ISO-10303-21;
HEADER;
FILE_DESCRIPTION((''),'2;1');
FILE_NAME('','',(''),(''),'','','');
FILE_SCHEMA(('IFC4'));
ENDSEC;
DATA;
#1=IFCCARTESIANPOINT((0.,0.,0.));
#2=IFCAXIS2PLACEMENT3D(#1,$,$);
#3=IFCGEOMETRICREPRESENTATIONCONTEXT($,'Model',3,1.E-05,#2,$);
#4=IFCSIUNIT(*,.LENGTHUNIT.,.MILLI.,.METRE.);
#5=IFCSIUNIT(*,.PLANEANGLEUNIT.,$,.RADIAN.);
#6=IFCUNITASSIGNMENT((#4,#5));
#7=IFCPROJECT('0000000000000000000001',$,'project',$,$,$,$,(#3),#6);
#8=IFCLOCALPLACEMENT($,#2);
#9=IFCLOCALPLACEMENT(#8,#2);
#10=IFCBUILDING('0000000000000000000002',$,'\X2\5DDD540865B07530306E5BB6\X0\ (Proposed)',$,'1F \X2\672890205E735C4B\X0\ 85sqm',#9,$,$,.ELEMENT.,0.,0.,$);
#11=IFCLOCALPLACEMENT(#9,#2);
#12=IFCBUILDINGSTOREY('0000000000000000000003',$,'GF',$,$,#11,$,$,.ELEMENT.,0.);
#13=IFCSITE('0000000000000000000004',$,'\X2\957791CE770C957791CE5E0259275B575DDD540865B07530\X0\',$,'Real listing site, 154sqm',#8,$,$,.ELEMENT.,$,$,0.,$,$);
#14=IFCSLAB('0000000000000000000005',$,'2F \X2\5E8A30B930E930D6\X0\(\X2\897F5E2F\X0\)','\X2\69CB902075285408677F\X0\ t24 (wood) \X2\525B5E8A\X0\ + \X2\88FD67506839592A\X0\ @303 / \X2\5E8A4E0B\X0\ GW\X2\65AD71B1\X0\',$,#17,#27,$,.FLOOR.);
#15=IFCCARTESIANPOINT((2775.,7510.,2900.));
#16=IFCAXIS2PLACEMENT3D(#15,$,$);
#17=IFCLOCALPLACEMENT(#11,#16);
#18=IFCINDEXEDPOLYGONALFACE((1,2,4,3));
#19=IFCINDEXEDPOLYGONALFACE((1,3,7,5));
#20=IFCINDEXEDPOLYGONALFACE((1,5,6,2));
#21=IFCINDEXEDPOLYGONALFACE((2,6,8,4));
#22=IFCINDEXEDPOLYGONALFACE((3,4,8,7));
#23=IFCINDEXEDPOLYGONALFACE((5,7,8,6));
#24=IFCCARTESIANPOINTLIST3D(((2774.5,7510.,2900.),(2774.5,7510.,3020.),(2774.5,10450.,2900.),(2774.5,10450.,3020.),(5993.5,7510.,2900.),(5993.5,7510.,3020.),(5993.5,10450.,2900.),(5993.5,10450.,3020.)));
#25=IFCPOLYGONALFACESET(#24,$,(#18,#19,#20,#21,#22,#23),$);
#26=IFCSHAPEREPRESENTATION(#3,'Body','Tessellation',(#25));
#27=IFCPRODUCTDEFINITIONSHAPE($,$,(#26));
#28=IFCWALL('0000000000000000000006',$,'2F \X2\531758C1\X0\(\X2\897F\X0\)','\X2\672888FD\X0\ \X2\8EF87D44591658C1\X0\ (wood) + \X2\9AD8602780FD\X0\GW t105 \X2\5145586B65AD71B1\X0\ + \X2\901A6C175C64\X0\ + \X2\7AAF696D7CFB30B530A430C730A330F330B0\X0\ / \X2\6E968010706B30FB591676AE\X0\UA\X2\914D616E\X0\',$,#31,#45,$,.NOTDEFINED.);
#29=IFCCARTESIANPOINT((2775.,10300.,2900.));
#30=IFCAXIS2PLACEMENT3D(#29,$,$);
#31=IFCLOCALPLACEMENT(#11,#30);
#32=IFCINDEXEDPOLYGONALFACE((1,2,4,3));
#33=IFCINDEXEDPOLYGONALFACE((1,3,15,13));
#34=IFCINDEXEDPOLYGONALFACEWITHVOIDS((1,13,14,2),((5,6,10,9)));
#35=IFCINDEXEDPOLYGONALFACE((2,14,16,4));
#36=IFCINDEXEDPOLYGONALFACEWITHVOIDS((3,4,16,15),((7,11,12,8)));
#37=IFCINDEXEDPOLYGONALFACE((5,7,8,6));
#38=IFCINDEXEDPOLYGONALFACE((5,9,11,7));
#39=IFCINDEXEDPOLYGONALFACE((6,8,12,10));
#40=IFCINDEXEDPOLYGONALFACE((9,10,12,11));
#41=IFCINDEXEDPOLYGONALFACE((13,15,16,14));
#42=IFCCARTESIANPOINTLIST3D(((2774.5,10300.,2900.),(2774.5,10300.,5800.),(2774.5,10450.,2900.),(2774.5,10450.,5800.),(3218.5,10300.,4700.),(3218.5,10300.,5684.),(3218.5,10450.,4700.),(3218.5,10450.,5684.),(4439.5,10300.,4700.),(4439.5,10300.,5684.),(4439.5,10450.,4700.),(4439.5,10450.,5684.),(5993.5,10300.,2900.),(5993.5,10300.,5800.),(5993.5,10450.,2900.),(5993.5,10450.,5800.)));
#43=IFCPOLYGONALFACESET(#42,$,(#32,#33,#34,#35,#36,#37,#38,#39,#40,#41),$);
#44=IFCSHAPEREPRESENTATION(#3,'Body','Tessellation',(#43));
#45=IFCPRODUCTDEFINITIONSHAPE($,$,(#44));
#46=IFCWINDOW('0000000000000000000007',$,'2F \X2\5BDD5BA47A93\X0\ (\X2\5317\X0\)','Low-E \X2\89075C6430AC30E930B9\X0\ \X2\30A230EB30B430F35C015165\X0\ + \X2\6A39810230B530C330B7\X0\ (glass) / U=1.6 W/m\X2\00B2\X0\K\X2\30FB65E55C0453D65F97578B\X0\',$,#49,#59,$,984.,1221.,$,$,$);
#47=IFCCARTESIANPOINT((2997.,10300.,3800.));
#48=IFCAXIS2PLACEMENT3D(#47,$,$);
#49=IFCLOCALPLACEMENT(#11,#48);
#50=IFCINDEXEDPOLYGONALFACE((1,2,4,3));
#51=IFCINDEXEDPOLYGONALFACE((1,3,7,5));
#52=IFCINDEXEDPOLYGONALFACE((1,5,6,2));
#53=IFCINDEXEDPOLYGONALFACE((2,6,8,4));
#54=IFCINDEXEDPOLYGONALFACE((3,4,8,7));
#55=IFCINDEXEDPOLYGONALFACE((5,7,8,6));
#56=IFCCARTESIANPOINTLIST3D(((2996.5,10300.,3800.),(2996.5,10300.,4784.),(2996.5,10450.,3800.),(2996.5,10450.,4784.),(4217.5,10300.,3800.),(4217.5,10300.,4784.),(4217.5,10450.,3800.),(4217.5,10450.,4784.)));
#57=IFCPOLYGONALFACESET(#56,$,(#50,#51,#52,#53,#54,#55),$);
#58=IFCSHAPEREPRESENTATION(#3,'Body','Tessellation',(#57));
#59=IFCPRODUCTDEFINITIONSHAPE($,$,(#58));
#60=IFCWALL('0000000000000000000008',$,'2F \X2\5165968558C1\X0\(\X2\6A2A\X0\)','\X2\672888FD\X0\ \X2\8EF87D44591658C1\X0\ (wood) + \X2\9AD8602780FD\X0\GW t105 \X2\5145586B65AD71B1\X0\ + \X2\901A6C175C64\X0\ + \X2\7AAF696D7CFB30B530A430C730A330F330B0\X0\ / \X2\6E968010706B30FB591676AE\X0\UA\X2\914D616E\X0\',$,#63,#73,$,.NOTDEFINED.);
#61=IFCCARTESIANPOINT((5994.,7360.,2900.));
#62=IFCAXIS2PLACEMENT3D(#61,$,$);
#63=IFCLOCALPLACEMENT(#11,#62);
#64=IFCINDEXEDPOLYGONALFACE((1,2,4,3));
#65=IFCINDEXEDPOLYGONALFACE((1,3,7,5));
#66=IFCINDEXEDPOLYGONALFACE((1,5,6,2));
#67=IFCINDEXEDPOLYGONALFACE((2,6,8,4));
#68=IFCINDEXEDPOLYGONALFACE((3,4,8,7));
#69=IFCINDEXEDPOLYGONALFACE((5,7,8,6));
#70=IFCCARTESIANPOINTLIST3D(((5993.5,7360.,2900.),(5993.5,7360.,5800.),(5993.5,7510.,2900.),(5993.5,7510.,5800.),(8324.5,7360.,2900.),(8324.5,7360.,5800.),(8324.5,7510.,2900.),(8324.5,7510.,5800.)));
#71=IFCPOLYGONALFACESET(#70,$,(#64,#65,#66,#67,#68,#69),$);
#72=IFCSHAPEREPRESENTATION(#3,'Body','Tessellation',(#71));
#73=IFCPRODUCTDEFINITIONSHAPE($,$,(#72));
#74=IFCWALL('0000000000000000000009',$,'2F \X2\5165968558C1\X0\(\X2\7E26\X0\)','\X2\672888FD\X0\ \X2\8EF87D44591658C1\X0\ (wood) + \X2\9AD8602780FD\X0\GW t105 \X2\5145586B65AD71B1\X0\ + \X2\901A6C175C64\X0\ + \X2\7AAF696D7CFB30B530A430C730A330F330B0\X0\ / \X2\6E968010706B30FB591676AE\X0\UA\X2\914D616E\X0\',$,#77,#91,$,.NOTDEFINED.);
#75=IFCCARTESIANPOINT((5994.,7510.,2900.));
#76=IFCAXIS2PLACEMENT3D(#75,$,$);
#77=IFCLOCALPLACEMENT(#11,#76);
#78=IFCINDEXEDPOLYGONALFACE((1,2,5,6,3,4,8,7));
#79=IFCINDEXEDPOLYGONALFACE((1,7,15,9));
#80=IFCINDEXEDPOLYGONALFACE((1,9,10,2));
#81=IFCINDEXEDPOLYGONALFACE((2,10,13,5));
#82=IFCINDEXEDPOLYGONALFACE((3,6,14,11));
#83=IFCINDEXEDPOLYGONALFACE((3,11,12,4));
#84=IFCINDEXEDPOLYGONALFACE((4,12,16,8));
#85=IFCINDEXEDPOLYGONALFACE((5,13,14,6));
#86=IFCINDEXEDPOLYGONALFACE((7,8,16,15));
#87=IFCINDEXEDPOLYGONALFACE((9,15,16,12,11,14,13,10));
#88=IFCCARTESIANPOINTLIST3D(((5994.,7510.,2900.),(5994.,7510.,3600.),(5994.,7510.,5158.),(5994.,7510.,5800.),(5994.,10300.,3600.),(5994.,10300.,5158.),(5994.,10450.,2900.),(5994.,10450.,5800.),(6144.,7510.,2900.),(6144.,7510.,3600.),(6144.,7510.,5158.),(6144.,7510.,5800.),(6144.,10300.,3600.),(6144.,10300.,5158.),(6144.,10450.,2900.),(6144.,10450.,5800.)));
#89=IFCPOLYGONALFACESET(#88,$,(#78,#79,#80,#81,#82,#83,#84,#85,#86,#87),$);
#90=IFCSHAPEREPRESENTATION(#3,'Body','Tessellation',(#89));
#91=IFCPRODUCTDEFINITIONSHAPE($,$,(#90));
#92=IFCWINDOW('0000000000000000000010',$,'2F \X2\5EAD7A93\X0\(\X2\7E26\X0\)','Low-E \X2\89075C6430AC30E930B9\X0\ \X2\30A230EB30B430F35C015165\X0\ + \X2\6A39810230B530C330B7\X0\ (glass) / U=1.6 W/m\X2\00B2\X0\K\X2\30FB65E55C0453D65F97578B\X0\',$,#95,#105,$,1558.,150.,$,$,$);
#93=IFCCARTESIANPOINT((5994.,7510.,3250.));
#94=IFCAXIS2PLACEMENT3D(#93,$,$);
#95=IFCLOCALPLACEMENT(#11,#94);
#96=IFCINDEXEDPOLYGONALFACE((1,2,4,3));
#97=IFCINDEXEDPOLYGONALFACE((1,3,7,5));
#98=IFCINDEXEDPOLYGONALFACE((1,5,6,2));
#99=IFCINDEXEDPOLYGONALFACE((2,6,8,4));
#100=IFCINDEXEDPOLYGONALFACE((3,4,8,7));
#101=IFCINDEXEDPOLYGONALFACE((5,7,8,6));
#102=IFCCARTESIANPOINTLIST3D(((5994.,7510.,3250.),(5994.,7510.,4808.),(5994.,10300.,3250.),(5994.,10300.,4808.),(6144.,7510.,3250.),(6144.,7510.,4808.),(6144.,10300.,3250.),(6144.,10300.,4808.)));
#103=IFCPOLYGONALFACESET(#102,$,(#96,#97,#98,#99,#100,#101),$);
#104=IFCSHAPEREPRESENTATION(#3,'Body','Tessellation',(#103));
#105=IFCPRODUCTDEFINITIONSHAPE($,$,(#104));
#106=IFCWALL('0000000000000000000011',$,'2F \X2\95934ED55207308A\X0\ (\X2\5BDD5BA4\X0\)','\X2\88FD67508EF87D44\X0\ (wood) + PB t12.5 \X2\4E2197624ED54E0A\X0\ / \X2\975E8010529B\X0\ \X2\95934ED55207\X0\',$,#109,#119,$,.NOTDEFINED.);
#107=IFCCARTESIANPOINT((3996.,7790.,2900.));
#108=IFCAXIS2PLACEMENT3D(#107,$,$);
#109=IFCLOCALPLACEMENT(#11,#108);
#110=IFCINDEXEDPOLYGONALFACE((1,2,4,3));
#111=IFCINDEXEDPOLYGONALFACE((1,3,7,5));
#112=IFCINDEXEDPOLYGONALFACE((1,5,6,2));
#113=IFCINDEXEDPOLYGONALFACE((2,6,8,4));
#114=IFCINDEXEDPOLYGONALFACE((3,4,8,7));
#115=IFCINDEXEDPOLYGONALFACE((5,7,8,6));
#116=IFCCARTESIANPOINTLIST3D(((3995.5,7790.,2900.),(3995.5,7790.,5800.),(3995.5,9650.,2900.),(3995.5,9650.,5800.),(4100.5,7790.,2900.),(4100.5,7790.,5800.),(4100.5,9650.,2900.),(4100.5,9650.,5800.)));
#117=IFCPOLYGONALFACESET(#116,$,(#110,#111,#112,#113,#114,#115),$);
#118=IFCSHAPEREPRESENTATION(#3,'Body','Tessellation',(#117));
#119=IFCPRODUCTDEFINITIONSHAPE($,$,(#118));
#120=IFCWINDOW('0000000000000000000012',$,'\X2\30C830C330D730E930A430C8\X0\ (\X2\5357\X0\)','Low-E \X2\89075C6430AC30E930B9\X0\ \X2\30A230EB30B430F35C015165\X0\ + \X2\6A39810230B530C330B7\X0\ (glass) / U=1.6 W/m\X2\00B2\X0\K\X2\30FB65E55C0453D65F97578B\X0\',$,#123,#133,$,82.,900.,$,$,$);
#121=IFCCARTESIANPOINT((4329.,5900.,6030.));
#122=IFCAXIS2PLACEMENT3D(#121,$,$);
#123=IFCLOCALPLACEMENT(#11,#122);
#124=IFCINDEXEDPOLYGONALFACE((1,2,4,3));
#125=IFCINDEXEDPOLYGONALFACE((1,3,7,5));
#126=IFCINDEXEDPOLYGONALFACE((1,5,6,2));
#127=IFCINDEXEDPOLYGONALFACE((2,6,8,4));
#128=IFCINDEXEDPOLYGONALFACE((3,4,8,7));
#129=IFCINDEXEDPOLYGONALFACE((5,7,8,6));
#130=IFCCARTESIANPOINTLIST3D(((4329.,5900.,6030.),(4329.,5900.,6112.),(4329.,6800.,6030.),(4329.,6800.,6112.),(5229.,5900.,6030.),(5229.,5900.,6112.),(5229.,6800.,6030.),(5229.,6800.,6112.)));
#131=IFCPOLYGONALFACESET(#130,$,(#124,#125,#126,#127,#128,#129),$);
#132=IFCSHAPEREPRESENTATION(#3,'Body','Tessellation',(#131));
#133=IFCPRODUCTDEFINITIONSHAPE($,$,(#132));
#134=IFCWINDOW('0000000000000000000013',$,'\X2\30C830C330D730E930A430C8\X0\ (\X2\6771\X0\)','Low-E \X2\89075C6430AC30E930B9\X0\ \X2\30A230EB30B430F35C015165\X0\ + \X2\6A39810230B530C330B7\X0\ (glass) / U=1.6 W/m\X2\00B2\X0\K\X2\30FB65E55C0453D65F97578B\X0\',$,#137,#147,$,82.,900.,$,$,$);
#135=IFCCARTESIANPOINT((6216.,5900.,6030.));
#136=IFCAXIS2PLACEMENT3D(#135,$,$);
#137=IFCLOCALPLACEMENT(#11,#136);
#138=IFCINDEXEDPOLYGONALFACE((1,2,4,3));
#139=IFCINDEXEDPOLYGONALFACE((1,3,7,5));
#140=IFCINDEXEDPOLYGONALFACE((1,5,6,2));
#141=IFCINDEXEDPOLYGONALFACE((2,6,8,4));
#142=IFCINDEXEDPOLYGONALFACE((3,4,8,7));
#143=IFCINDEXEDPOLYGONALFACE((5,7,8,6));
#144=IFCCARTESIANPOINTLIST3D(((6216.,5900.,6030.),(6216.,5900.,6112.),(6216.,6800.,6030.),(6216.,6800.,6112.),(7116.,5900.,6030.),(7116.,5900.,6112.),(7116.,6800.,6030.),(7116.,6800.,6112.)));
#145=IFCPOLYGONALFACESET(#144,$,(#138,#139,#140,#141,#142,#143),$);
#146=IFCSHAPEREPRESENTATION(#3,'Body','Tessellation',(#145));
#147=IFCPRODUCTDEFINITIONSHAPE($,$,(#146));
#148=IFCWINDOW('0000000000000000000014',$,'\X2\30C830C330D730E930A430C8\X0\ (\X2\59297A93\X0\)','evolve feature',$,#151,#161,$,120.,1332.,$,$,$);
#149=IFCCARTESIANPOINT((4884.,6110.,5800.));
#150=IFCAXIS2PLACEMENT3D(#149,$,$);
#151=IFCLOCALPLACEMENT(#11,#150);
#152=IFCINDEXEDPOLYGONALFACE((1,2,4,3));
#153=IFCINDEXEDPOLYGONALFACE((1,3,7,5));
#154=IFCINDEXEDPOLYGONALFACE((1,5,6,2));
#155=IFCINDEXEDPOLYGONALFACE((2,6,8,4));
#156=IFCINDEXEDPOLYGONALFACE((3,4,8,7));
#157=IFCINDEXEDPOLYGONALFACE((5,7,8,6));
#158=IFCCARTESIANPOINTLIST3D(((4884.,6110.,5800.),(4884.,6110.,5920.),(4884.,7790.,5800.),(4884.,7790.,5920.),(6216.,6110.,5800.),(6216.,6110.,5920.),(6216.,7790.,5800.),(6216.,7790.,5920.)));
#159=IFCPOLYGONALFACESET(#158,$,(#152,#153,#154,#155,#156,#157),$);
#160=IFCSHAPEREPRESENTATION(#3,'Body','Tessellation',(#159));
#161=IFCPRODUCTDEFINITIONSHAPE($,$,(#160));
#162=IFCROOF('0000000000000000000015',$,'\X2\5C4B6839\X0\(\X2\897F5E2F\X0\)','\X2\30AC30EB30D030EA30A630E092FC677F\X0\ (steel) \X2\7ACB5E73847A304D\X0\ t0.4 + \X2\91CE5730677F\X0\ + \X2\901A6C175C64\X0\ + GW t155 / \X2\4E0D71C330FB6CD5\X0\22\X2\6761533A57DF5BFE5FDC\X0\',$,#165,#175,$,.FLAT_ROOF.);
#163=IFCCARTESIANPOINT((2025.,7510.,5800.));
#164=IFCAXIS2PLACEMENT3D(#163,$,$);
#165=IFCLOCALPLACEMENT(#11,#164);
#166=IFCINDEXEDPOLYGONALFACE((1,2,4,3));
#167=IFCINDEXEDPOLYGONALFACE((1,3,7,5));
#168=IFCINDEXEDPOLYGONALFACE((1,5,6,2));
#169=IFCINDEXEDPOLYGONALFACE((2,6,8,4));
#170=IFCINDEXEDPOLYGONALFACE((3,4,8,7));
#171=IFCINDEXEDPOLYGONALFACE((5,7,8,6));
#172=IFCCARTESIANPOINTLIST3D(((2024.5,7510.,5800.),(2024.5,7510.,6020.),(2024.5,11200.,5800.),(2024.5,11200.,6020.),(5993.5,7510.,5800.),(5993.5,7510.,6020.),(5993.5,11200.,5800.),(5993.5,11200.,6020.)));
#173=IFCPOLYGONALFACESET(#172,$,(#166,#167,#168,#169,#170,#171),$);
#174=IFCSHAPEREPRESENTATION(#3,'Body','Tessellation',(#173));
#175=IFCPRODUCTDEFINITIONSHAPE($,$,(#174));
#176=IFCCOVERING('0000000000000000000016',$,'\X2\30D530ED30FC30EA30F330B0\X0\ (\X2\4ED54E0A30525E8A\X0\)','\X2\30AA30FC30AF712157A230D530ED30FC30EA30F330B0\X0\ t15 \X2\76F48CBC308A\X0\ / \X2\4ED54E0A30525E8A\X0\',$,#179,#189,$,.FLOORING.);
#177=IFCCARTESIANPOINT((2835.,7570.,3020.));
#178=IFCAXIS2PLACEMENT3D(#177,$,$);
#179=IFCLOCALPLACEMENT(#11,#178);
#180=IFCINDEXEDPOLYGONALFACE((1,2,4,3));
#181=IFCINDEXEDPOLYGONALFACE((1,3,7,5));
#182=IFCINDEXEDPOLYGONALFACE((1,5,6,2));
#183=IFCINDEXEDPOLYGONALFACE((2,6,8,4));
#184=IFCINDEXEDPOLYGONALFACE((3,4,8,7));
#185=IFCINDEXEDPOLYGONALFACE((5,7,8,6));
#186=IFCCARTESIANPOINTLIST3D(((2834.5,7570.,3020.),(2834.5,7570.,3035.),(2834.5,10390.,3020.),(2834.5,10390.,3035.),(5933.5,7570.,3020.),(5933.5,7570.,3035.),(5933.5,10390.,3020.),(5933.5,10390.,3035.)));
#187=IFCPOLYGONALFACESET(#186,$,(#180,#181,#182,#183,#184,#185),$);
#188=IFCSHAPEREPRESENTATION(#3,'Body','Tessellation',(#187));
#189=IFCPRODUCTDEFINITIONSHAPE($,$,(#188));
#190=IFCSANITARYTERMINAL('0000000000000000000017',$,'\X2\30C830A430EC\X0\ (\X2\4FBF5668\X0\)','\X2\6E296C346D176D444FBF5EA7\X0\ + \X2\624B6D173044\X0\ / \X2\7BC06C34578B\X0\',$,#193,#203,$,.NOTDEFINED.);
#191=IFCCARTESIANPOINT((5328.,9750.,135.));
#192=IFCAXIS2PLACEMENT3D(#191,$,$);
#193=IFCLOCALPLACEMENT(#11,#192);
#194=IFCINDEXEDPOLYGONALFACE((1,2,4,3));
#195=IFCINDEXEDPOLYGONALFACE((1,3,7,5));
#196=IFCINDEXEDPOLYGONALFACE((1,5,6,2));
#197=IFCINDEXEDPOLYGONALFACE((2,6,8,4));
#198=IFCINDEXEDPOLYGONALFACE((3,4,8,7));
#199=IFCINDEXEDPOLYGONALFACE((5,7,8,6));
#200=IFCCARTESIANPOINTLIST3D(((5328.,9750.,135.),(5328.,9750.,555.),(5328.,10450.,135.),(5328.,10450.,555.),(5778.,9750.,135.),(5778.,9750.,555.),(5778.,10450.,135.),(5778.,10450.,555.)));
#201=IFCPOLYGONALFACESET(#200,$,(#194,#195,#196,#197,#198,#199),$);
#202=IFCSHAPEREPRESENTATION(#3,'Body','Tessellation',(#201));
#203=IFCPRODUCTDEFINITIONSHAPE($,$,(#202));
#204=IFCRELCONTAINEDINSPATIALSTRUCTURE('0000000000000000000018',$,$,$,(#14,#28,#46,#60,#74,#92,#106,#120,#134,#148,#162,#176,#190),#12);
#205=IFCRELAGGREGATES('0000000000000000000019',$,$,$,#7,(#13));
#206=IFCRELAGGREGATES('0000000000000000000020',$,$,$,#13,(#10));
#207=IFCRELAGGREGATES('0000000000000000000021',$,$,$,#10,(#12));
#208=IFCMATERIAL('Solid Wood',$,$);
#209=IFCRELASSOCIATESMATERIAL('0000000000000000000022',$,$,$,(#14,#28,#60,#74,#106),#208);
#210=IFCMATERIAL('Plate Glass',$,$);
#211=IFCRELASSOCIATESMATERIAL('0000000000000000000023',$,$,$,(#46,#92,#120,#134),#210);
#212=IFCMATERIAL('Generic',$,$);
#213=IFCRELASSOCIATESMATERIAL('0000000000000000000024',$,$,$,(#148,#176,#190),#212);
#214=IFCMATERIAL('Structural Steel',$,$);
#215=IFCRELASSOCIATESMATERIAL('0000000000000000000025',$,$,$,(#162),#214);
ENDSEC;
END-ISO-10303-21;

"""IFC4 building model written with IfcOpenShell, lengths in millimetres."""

from ifc_helpers import new_model, si_unit, frame, frame_2d, origin, place, context, project, spatial, rectangle, extrude, material, element, fill, save


model = new_model("IFC4")

# Units and contexts
model_context = context("Model", 3, precision=1e-05, world=origin())
ifc_project = project(units=[si_unit("LENGTHUNIT", "METRE", prefix="MILLI"), si_unit("PLANEANGLEUNIT", "RADIAN")], contexts=[model_context])

# Site, building, storey
site_placement = place(None, origin())
site = spatial("IfcSite", under=ifc_project, at=site_placement, Name="長野県長野市大字川合新田", ObjectType="Real listing site, 154sqm", CompositionType="ELEMENT", RefElevation=0.0)
building_placement = place(site_placement, origin())
building = spatial("IfcBuilding", under=site, at=building_placement, Name="川合新田の家 (Proposed)", ObjectType="1F 木造平屋 85sqm", CompositionType="ELEMENT", ElevationOfRefHeight=0.0, ElevationOfTerrain=0.0)
storey_placement = place(building_placement, origin())
storey = spatial("IfcBuildingStorey", under=building, at=storey_placement, Name="GF", CompositionType="ELEMENT", Elevation=0.0)

# Slab
ifc_material_1 = material(Name="Solid Wood")
slab_placement = place(storey_placement, frame((2775.0, 7510.0, 2900.0)))
element("IfcSlab", 1, at=slab_placement, inside=storey, material=ifc_material_1, Name="2F 床スラブ(西帯)", Description="構造用合板 t24 (wood) 剛床 + 製材根太 @303 / 床下 GW断熱", PredefinedType="FLOOR", context=model_context, shape_type="SweptSolid", body=[
    extrude(rectangle(XDim=3219.0, YDim=2940.0, at=frame_2d((1609.0, 1470.0))), frame((2775.0, 7510.0, 2900.0)), (0.0, 0.0, 1.0), 120.0),
])

# Wall, opening, window
wall_1_placement = place(storey_placement, frame((2775.0, 10300.0, 2900.0)))
wall_1 = element("IfcWall", 2, at=wall_1_placement, inside=storey, material=ifc_material_1, Name="2F 北壁(西)", Description="木製 軸組外壁 (wood) + 高性能GW t105 充填断熱 + 通気層 + 窯業系サイディング / 準耐火・外皮UA配慮", PredefinedType="NOTDEFINED", context=model_context, shape_type="SweptSolid", body=[
    extrude(rectangle(XDim=3219.0, YDim=150.0, at=frame_2d((1609.0, 75.0))), frame((2775.0, 10300.0, 2900.0)), (0.0, 0.0, 1.0), 2900.0),
])
opening_1_placement = place(storey_placement, frame((2997.0, 10300.0, 3800.0)))
opening_1 = element("IfcOpeningElement", 3, at=opening_1_placement, cuts=wall_1, PredefinedType="NOTDEFINED", context=model_context, shape_type="SweptSolid", body=[
    extrude(rectangle(XDim=1221.0, YDim=150.0, at=frame_2d((610.0, 75.0))), frame((2997.0, 10300.0, 3800.0)), (0.0, 0.0, 1.0), 984.0),
])
ifc_material_2 = material(Name="Plate Glass")
window_1_placement = place(storey_placement, frame((2997.0, 10300.0, 3800.0)))
window_1 = element("IfcWindow", 4, at=window_1_placement, inside=storey, material=ifc_material_2, Name="2F 寝室窓 (北)", Description="Low-E 複層ガラス アルゴン封入 + 樹脂サッシ (glass) / U=1.6 W/m²K・日射取得型", OverallHeight=984.0, OverallWidth=1221.0, context=model_context, shape_type="SweptSolid", body=[
    extrude(rectangle(XDim=1221.0, YDim=150.0, at=frame_2d((610.0, 75.0))), frame((2997.0, 10300.0, 3800.0)), (0.0, 0.0, 1.0), 984.0),
])
fill(opening_1, window_1)

# Wall
wall_2_placement = place(storey_placement, frame((5994.0, 7360.0, 2900.0)))
element("IfcWall", 5, at=wall_2_placement, inside=storey, material=ifc_material_1, Name="2F 入隅壁(横)", Description="木製 軸組外壁 (wood) + 高性能GW t105 充填断熱 + 通気層 + 窯業系サイディング / 準耐火・外皮UA配慮", PredefinedType="NOTDEFINED", context=model_context, shape_type="SweptSolid", body=[
    extrude(rectangle(XDim=2331.0, YDim=150.0, at=frame_2d((1165.0, 75.0))), frame((5994.0, 7360.0, 2900.0)), (0.0, 0.0, 1.0), 2900.0),
])

# Wall, opening, window
wall_3_placement = place(storey_placement, frame((5994.0, 7510.0, 2900.0)))
wall_3 = element("IfcWall", 6, at=wall_3_placement, inside=storey, material=ifc_material_1, Name="2F 入隅壁(縦)", Description="木製 軸組外壁 (wood) + 高性能GW t105 充填断熱 + 通気層 + 窯業系サイディング / 準耐火・外皮UA配慮", PredefinedType="NOTDEFINED", context=model_context, shape_type="SweptSolid", body=[
    extrude(rectangle(XDim=150.0, YDim=2940.0, at=frame_2d((75.0, 1470.0))), frame((5994.0, 7510.0, 2900.0)), (0.0, 0.0, 1.0), 2900.0),
])
opening_2_placement = place(storey_placement, frame((5994.0, 7510.0, 3250.0)))
opening_2 = element("IfcOpeningElement", 7, at=opening_2_placement, cuts=wall_3, PredefinedType="NOTDEFINED", context=model_context, shape_type="SweptSolid", body=[
    extrude(rectangle(XDim=150.0, YDim=2790.0, at=frame_2d((75.0, 1395.0))), frame((5994.0, 7510.0, 3250.0)), (0.0, 0.0, 1.0), 1558.0),
])
window_2_placement = place(storey_placement, frame((5994.0, 7510.0, 3250.0)))
window_2 = element("IfcWindow", 8, at=window_2_placement, inside=storey, material=ifc_material_2, Name="2F 庭窓(縦)", Description="Low-E 複層ガラス アルゴン封入 + 樹脂サッシ (glass) / U=1.6 W/m²K・日射取得型", OverallHeight=1558.0, OverallWidth=150.0, context=model_context, shape_type="SweptSolid", body=[
    extrude(rectangle(XDim=150.0, YDim=2790.0, at=frame_2d((75.0, 1395.0))), frame((5994.0, 7510.0, 3250.0)), (0.0, 0.0, 1.0), 1558.0),
])
fill(opening_2, window_2)

# Wall
wall_4_placement = place(storey_placement, frame((3996.0, 7790.0, 2900.0)))
element("IfcWall", 9, at=wall_4_placement, inside=storey, material=ifc_material_1, Name="2F 間仕切り (寝室)", Description="製材軸組 (wood) + PB t12.5 両面仕上 / 非耐力 間仕切", PredefinedType="NOTDEFINED", context=model_context, shape_type="SweptSolid", body=[
    extrude(rectangle(XDim=105.0, YDim=1860.0, at=frame_2d((52.0, 930.0))), frame((3996.0, 7790.0, 2900.0)), (0.0, 0.0, 1.0), 2900.0),
])

# Windows
window_3_placement = place(storey_placement, frame((4329.0, 5900.0, 6030.0)))
element("IfcWindow", 10, at=window_3_placement, inside=storey, material=ifc_material_2, Name="トップライト (南)", Description="Low-E 複層ガラス アルゴン封入 + 樹脂サッシ (glass) / U=1.6 W/m²K・日射取得型", OverallHeight=82.0, OverallWidth=900.0, context=model_context, shape_type="SweptSolid", body=[
    extrude(rectangle(XDim=900.0, YDim=900.0, at=frame_2d((450.0, 450.0))), frame((4329.0, 5900.0, 6030.0)), (0.0, 0.0, 1.0), 82.0),
])
window_4_placement = place(storey_placement, frame((6216.0, 5900.0, 6030.0)))
element("IfcWindow", 11, at=window_4_placement, inside=storey, material=ifc_material_2, Name="トップライト (東)", Description="Low-E 複層ガラス アルゴン封入 + 樹脂サッシ (glass) / U=1.6 W/m²K・日射取得型", OverallHeight=82.0, OverallWidth=900.0, context=model_context, shape_type="SweptSolid", body=[
    extrude(rectangle(XDim=900.0, YDim=900.0, at=frame_2d((450.0, 450.0))), frame((6216.0, 5900.0, 6030.0)), (0.0, 0.0, 1.0), 82.0),
])
ifc_material_3 = material(Name="Generic")
window_5_placement = place(storey_placement, frame((4884.0, 6110.0, 5800.0)))
element("IfcWindow", 12, at=window_5_placement, inside=storey, material=ifc_material_3, Name="トップライト (天窓)", Description="evolve feature", OverallHeight=120.0, OverallWidth=1332.0, context=model_context, shape_type="SweptSolid", body=[
    extrude(rectangle(XDim=1332.0, YDim=1680.0, at=frame_2d((666.0, 840.0))), frame((4884.0, 6110.0, 5800.0)), (0.0, 0.0, 1.0), 120.0),
])

# Roof
ifc_material_4 = material(Name="Structural Steel")
for number, where, name in (
    (13, (2025.0, 7510.0, 5800.0), "屋根(西帯)"),
):
    element("IfcRoof", number, at=place(storey_placement, frame(where)), inside=storey, material=ifc_material_4, Name=name, Description="ガルバリウム鋼板 (steel) 立平葺き t0.4 + 野地板 + 通気層 + GW t155 / 不燃・法22条区域対応", PredefinedType="FLAT_ROOF", context=model_context, shape_type="SweptSolid", body=[
        extrude(rectangle(XDim=3969.0, YDim=3690.0, at=frame_2d((1984.0, 1845.0))), frame((2025.0, 7510.0, 5800.0)), (0.0, 0.0, 1.0), 220.0),
    ])

# Covering
covering_placement = place(storey_placement, frame((2835.0, 7570.0, 3020.0)))
element("IfcCovering", 14, at=covering_placement, inside=storey, material=ifc_material_3, Name="フローリング (仕上げ床)", Description="オーク無垢フローリング t15 直貼り / 仕上げ床", PredefinedType="FLOORING", context=model_context, shape_type="SweptSolid", body=[
    extrude(rectangle(XDim=3099.0, YDim=2820.0, at=frame_2d((1549.0, 1410.0))), frame((2835.0, 7570.0, 3020.0)), (0.0, 0.0, 1.0), 15.0),
])

# Sanitary terminal
sanitary_terminal_placement = place(storey_placement, frame((5328.0, 9750.0, 135.0)))
element("IfcSanitaryTerminal", 15, at=sanitary_terminal_placement, inside=storey, material=ifc_material_3, Name="トイレ (便器)", Description="温水洗浄便座 + 手洗い / 節水型", PredefinedType="NOTDEFINED", context=model_context, shape_type="SweptSolid", body=[
    extrude(rectangle(XDim=450.0, YDim=700.0, at=frame_2d((225.0, 350.0))), frame((5328.0, 9750.0, 135.0)), (0.0, 0.0, 1.0), 420.0),
])

save(model, "model.ifc")
